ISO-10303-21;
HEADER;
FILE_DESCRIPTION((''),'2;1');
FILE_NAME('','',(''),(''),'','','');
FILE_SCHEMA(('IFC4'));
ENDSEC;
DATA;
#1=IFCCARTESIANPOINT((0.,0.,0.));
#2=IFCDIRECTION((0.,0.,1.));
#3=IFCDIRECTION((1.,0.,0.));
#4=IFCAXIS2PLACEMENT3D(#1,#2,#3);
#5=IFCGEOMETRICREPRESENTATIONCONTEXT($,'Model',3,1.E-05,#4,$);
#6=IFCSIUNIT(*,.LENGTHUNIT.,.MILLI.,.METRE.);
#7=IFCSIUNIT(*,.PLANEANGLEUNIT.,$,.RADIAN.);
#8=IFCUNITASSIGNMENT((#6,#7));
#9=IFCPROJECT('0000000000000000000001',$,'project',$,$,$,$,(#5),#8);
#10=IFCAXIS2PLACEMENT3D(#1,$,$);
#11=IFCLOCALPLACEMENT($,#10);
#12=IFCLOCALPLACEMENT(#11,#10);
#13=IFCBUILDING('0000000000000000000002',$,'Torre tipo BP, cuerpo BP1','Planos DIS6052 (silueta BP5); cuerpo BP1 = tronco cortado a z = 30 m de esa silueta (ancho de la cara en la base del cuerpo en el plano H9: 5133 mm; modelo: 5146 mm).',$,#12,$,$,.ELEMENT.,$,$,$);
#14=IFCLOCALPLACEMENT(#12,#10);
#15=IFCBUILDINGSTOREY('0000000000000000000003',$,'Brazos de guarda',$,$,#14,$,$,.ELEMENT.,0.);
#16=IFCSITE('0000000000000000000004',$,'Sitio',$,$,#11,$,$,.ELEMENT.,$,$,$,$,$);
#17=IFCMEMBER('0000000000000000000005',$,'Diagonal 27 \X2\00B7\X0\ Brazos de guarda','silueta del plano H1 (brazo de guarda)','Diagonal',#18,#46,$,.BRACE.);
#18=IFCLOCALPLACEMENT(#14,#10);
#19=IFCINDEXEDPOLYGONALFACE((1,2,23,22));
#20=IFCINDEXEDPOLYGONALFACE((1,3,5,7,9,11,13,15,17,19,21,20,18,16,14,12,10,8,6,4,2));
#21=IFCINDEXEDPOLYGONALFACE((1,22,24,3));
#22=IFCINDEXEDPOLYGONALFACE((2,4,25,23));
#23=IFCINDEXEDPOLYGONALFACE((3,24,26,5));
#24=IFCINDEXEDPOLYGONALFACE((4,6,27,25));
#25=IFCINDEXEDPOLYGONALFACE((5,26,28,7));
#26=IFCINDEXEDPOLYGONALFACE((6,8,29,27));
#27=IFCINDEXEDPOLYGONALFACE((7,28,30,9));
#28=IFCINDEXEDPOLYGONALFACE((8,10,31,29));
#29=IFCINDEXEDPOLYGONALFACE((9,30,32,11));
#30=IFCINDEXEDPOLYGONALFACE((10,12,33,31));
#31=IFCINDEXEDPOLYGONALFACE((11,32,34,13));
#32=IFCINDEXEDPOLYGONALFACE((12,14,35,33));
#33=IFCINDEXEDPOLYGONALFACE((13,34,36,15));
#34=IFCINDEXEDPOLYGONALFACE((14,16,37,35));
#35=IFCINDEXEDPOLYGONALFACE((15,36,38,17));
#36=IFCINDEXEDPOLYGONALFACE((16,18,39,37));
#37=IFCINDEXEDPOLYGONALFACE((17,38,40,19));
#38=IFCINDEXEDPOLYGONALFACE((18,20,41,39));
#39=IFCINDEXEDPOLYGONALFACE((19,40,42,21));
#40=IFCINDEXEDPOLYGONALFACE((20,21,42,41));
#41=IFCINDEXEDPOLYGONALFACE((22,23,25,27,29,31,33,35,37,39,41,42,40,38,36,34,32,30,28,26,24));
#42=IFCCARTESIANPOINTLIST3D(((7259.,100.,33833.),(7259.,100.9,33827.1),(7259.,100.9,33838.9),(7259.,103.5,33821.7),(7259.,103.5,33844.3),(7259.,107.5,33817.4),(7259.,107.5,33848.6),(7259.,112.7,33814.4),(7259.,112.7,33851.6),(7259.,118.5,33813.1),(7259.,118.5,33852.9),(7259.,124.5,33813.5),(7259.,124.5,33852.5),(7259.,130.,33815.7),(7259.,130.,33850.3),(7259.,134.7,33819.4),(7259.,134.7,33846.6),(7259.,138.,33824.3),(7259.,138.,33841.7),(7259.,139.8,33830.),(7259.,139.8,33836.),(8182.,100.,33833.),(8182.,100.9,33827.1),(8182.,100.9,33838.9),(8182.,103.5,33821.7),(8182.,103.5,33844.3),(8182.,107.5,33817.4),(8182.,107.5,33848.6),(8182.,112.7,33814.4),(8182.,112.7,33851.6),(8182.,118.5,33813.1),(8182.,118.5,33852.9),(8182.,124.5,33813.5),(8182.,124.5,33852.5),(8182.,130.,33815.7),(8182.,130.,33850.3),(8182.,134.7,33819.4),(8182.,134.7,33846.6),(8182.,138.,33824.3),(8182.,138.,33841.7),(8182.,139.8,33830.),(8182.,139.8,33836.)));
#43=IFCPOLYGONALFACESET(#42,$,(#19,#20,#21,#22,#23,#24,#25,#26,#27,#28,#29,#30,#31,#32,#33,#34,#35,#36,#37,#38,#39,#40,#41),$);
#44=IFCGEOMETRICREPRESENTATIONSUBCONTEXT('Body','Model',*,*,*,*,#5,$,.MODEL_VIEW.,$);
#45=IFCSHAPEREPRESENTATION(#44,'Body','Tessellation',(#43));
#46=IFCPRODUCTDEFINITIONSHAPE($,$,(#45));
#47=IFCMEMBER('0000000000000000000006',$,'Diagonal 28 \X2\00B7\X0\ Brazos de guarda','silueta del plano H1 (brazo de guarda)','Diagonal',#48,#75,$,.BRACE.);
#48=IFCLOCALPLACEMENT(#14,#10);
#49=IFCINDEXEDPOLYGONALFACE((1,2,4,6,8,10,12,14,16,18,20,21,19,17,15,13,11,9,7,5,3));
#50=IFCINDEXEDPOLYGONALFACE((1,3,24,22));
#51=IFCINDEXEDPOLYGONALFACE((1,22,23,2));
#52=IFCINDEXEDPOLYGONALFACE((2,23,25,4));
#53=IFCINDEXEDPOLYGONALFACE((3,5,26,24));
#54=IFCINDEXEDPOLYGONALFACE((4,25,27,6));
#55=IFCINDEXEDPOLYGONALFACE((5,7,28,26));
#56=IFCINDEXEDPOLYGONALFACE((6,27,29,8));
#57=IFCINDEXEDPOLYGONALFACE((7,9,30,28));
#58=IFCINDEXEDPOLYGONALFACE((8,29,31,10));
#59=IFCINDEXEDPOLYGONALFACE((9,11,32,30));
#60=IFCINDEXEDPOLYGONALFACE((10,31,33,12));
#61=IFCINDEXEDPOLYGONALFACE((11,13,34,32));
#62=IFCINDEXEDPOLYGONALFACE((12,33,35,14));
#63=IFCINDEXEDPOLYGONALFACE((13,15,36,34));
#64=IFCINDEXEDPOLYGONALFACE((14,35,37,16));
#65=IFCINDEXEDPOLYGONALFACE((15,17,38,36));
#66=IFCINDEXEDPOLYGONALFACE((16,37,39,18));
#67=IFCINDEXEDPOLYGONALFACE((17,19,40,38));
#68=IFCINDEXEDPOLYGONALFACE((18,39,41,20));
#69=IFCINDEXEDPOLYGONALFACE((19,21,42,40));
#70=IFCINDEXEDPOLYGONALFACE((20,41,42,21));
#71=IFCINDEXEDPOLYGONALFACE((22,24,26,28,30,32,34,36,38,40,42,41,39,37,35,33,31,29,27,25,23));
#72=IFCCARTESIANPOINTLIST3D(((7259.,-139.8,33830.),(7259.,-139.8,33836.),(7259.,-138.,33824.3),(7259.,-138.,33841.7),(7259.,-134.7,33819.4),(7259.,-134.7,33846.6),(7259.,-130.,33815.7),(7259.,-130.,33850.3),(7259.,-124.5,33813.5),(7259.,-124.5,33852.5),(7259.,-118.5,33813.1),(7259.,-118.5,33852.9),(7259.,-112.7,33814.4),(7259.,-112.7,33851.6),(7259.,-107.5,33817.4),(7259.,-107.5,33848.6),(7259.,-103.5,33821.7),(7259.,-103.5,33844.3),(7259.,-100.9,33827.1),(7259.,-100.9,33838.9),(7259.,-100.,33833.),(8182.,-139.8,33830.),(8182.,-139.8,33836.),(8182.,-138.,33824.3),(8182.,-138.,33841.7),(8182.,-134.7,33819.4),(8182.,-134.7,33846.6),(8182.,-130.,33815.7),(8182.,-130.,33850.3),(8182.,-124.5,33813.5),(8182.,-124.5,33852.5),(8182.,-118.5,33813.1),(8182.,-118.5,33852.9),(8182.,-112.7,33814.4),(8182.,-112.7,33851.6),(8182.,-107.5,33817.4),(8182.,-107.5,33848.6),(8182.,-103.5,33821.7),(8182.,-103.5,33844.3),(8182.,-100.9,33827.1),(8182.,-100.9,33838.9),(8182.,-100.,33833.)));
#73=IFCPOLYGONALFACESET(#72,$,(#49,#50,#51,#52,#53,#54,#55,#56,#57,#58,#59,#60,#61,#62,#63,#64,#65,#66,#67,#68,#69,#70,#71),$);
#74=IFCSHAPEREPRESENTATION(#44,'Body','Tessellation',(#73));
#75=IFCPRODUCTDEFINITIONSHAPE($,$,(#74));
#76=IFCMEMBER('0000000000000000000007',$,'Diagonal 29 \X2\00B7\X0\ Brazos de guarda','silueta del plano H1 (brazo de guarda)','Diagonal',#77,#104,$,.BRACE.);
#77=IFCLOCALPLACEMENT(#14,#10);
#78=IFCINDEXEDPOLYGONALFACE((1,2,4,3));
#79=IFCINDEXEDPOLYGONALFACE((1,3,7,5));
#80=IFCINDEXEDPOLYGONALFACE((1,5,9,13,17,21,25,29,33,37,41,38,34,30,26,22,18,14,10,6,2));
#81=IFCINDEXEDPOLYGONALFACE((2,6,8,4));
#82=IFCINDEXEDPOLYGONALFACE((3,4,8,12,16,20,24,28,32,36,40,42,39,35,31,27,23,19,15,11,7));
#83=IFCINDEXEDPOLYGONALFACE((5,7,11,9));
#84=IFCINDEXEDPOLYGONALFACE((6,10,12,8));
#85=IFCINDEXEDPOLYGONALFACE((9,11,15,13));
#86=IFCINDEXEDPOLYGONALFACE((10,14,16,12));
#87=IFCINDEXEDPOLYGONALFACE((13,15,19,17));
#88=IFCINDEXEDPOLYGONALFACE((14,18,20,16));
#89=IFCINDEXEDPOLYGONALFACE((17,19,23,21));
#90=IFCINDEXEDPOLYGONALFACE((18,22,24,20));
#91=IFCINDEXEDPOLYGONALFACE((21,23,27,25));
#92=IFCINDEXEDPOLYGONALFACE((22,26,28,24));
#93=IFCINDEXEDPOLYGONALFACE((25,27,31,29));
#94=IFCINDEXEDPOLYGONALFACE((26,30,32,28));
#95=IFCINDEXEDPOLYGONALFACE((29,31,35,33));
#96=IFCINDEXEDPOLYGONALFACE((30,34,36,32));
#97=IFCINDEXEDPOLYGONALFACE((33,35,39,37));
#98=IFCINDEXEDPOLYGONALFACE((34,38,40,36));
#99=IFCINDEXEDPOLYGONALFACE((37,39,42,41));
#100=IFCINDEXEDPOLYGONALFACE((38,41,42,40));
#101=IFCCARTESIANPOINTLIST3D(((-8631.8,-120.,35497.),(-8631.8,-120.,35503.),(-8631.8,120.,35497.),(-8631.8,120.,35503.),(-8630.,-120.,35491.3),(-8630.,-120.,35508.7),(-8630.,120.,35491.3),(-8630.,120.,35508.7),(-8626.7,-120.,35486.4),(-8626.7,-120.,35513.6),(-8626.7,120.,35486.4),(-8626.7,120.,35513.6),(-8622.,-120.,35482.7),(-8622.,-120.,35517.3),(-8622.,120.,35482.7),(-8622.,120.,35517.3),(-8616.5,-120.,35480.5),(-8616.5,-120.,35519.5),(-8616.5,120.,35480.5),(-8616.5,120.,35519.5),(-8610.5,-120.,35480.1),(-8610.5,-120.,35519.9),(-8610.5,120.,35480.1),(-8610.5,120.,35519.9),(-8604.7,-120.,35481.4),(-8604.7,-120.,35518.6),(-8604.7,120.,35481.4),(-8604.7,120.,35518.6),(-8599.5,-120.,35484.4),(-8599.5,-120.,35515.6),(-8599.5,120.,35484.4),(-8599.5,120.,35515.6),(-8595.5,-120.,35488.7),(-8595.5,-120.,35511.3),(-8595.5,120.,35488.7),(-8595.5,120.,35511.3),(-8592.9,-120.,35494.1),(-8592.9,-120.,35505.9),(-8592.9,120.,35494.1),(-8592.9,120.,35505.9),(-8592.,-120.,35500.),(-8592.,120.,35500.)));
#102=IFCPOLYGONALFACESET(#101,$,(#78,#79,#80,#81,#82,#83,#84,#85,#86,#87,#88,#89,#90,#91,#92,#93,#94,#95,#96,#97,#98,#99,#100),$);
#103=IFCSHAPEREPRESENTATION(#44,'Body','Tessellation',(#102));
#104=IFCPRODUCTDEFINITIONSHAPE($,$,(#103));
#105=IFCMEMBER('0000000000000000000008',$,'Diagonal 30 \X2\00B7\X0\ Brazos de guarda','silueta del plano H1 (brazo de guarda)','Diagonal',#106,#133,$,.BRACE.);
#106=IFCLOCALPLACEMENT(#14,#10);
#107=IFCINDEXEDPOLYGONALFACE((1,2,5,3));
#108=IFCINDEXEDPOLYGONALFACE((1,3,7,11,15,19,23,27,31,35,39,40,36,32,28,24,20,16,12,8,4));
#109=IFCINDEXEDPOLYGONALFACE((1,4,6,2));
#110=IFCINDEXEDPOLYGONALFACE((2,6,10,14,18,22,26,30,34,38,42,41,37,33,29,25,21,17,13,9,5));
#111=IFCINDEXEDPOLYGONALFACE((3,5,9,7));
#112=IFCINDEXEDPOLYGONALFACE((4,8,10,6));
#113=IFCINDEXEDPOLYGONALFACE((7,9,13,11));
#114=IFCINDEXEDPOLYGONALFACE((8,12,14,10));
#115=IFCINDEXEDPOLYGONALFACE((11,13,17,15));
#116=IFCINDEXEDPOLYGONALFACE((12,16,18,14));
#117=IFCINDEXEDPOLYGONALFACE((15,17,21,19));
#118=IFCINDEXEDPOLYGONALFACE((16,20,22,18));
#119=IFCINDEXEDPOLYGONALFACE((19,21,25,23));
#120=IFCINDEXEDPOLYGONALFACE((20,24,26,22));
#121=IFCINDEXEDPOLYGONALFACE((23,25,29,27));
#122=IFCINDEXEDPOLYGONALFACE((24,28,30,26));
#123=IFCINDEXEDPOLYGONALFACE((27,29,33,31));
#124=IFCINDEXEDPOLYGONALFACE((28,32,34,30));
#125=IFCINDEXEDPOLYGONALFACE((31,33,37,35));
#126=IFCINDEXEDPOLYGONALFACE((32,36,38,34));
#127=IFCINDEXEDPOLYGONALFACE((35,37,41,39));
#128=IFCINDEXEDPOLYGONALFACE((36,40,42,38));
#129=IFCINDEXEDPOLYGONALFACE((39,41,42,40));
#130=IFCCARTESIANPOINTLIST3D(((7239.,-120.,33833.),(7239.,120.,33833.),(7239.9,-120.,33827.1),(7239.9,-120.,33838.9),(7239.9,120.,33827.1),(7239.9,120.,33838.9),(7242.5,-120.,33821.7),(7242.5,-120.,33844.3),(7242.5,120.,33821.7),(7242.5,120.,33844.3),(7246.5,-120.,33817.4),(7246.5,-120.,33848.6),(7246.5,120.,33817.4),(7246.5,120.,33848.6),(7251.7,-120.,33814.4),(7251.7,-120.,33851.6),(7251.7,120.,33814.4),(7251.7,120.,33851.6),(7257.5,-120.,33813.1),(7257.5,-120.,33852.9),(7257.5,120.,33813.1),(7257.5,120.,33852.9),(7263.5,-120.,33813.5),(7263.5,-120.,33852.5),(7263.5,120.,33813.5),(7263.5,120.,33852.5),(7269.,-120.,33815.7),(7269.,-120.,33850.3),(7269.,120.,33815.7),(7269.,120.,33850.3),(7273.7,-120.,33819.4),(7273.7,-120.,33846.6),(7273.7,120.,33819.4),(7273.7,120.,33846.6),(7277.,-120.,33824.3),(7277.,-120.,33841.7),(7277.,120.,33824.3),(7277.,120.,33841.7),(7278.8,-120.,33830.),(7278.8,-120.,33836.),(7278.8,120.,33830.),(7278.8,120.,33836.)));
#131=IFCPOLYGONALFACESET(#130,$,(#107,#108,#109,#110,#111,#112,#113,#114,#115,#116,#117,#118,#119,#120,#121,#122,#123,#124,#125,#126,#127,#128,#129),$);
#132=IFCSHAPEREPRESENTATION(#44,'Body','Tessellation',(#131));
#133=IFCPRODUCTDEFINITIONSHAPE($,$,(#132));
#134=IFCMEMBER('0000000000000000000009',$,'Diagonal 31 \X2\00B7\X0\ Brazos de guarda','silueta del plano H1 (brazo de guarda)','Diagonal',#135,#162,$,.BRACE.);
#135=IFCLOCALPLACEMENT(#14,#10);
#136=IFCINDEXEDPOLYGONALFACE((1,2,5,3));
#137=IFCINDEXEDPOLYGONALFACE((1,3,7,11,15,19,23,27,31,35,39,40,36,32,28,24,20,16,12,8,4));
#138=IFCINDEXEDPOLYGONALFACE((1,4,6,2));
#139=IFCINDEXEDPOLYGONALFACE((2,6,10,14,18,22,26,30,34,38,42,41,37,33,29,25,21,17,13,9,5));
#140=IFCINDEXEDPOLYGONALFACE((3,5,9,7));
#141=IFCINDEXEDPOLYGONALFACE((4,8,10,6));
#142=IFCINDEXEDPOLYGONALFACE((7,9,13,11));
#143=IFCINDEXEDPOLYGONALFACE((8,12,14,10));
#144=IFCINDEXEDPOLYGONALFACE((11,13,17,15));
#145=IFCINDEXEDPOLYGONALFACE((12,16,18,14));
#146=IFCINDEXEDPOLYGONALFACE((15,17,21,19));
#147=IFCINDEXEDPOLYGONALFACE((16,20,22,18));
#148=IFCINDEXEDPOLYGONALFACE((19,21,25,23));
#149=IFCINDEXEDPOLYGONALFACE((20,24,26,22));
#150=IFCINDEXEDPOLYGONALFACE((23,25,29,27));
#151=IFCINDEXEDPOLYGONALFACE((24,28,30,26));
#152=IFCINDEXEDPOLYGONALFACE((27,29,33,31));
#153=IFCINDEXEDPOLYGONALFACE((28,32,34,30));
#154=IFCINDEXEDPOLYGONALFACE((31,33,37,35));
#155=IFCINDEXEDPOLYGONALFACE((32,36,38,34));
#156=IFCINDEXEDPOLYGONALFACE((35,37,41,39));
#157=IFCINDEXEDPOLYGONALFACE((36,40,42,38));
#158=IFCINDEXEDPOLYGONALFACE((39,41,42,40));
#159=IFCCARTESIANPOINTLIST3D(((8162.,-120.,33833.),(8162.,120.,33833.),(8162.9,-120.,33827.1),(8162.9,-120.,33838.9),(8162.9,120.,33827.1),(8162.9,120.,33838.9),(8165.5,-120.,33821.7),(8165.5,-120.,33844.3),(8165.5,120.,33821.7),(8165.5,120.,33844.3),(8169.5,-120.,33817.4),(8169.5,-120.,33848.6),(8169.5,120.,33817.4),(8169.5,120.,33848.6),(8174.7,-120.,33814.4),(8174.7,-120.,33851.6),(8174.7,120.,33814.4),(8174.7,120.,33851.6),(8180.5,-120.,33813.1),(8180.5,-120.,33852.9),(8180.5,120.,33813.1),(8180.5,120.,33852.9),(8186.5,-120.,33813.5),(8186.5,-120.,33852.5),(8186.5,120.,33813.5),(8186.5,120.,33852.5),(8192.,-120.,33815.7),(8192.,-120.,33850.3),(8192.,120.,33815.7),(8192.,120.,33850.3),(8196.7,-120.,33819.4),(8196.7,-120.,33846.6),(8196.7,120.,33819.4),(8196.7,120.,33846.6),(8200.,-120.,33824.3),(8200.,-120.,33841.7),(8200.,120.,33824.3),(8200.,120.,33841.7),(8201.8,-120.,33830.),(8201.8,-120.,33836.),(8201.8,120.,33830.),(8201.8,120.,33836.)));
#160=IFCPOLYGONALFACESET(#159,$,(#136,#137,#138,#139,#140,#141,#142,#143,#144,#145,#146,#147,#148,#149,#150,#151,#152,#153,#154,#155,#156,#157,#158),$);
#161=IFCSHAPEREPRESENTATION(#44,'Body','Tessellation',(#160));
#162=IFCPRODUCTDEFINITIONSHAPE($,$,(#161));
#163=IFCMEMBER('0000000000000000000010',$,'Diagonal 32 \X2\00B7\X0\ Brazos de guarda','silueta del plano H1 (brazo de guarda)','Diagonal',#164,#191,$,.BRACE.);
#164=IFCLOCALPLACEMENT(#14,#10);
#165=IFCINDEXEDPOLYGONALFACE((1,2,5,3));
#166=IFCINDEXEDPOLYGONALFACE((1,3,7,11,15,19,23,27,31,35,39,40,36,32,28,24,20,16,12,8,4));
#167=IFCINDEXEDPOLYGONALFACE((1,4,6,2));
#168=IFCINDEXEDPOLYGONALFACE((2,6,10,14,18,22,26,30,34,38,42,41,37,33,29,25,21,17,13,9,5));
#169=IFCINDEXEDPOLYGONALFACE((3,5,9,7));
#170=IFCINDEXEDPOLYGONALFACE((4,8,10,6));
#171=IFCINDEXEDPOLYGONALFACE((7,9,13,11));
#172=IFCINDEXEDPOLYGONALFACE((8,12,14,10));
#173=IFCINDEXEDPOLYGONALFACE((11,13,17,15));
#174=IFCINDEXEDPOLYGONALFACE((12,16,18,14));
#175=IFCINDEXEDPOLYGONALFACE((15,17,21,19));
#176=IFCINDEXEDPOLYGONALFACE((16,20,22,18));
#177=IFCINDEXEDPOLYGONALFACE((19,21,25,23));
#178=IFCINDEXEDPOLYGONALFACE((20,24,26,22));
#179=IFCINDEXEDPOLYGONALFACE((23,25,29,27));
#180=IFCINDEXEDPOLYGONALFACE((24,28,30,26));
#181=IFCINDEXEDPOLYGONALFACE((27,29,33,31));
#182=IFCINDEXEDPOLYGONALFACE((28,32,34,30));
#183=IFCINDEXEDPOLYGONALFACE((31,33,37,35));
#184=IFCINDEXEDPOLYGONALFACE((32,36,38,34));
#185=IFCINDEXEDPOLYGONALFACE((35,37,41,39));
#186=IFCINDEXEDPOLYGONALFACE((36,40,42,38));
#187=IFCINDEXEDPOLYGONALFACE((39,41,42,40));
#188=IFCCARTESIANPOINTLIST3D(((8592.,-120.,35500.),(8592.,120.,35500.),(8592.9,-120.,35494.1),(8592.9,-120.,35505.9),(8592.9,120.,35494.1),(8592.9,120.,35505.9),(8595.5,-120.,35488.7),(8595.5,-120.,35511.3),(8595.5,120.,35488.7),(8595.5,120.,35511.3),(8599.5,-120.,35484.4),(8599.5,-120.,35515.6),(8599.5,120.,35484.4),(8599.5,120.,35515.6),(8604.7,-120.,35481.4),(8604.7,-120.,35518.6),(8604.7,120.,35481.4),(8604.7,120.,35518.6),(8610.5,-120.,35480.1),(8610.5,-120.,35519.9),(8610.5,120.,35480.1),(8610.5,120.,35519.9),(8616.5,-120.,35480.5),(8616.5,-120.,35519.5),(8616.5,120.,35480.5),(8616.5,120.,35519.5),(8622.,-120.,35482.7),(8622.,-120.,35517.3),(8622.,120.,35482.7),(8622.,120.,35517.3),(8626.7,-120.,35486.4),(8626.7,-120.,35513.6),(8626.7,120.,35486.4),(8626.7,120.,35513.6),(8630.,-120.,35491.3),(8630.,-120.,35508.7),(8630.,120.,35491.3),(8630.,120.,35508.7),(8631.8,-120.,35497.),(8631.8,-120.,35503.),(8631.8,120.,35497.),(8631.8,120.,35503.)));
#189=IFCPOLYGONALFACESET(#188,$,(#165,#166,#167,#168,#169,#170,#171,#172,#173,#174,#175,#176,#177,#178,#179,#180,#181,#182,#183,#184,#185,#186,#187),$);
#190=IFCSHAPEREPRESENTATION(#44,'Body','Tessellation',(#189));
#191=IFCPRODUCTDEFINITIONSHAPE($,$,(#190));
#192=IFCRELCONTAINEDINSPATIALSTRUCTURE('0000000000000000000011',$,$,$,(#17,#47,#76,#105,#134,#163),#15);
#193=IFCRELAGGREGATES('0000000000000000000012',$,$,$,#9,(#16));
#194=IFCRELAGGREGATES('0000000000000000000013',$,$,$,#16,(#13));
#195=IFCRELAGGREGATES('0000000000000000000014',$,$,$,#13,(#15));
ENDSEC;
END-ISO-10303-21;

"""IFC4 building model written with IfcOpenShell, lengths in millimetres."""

from ifc_helpers import new_model, si_unit, frame, origin, origin_with_axes, place, context, subcontext, project, spatial, circle, extrude, element, save


model = new_model("IFC4")

# Units and contexts
model_context = context("Model", 3, precision=1e-05, world=origin_with_axes())
body_context = subcontext(model_context, "Body", "Model", "MODEL_VIEW")
ifc_project = project(units=[si_unit("LENGTHUNIT", "METRE", prefix="MILLI"), si_unit("PLANEANGLEUNIT", "RADIAN")], contexts=[model_context])

# Site, building, storey
site_placement = place(None, origin())
site = spatial("IfcSite", under=ifc_project, at=site_placement, Name="Sitio", CompositionType="ELEMENT")
building_placement = place(site_placement, origin())
building = spatial("IfcBuilding", under=site, at=building_placement, Name="Torre tipo BP, cuerpo BP1", Description="Planos DIS6052 (silueta BP5); cuerpo BP1 = tronco cortado a z = 30 m de esa silueta (ancho de la cara en la base del cuerpo en el plano H9: 5133 mm; modelo: 5146 mm).", CompositionType="ELEMENT")
storey_placement = place(building_placement, origin())
storey = spatial("IfcBuildingStorey", under=building, at=storey_placement, Name="Brazos de guarda", CompositionType="ELEMENT", Elevation=0.0)

# Members
for number, where, z_axis, x_axis, name in (
    (1, (7259.0, 120.0, 33833.0), (1.0, 0.0, 0.0), (0.0, -1.0, 0.0), "Diagonal 27 · Brazos de guarda"),
    (2, (7259.0, -120.0, 33833.0), (1.0, 0.0, 0.0), (0.0, 1.0, 0.0), "Diagonal 28 · Brazos de guarda"),
):
    element("IfcMember", number, at=place(storey_placement, frame(where, z_axis=z_axis, x_axis=x_axis)), inside=storey, Name=name, Description="silueta del plano H1 (brazo de guarda)", ObjectType="Diagonal", PredefinedType="BRACE", context=body_context, shape_type="SweptSolid", body=[
        extrude(circle(Radius=20.0), None, (0.0, 0.0, 1.0), 923.0),
    ])
for number, where, z_axis, x_axis, name in (
    (3, (-8612.0, 120.0, 35500.0), (0.0, -1.0, 0.0), (1.0, 0.0, 0.0), "Diagonal 29 · Brazos de guarda"),
    (4, (7259.0, 120.0, 33833.0), (0.0, -1.0, 0.0), (-1.0, 0.0, 0.0), "Diagonal 30 · Brazos de guarda"),
    (5, (8182.0, 120.0, 33833.0), (0.0, -1.0, 0.0), (-1.0, 0.0, 0.0), "Diagonal 31 · Brazos de guarda"),
    (6, (8612.0, 120.0, 35500.0), (0.0, -1.0, 0.0), (-1.0, 0.0, 0.0), "Diagonal 32 · Brazos de guarda"),
):
    element("IfcMember", number, at=place(storey_placement, frame(where, z_axis=z_axis, x_axis=x_axis)), inside=storey, Name=name, Description="silueta del plano H1 (brazo de guarda)", ObjectType="Diagonal", PredefinedType="BRACE", context=body_context, shape_type="SweptSolid", body=[
        extrude(circle(Radius=20.0), None, (0.0, 0.0, 1.0), 240.0),
    ])

save(model, "model.ifc")
